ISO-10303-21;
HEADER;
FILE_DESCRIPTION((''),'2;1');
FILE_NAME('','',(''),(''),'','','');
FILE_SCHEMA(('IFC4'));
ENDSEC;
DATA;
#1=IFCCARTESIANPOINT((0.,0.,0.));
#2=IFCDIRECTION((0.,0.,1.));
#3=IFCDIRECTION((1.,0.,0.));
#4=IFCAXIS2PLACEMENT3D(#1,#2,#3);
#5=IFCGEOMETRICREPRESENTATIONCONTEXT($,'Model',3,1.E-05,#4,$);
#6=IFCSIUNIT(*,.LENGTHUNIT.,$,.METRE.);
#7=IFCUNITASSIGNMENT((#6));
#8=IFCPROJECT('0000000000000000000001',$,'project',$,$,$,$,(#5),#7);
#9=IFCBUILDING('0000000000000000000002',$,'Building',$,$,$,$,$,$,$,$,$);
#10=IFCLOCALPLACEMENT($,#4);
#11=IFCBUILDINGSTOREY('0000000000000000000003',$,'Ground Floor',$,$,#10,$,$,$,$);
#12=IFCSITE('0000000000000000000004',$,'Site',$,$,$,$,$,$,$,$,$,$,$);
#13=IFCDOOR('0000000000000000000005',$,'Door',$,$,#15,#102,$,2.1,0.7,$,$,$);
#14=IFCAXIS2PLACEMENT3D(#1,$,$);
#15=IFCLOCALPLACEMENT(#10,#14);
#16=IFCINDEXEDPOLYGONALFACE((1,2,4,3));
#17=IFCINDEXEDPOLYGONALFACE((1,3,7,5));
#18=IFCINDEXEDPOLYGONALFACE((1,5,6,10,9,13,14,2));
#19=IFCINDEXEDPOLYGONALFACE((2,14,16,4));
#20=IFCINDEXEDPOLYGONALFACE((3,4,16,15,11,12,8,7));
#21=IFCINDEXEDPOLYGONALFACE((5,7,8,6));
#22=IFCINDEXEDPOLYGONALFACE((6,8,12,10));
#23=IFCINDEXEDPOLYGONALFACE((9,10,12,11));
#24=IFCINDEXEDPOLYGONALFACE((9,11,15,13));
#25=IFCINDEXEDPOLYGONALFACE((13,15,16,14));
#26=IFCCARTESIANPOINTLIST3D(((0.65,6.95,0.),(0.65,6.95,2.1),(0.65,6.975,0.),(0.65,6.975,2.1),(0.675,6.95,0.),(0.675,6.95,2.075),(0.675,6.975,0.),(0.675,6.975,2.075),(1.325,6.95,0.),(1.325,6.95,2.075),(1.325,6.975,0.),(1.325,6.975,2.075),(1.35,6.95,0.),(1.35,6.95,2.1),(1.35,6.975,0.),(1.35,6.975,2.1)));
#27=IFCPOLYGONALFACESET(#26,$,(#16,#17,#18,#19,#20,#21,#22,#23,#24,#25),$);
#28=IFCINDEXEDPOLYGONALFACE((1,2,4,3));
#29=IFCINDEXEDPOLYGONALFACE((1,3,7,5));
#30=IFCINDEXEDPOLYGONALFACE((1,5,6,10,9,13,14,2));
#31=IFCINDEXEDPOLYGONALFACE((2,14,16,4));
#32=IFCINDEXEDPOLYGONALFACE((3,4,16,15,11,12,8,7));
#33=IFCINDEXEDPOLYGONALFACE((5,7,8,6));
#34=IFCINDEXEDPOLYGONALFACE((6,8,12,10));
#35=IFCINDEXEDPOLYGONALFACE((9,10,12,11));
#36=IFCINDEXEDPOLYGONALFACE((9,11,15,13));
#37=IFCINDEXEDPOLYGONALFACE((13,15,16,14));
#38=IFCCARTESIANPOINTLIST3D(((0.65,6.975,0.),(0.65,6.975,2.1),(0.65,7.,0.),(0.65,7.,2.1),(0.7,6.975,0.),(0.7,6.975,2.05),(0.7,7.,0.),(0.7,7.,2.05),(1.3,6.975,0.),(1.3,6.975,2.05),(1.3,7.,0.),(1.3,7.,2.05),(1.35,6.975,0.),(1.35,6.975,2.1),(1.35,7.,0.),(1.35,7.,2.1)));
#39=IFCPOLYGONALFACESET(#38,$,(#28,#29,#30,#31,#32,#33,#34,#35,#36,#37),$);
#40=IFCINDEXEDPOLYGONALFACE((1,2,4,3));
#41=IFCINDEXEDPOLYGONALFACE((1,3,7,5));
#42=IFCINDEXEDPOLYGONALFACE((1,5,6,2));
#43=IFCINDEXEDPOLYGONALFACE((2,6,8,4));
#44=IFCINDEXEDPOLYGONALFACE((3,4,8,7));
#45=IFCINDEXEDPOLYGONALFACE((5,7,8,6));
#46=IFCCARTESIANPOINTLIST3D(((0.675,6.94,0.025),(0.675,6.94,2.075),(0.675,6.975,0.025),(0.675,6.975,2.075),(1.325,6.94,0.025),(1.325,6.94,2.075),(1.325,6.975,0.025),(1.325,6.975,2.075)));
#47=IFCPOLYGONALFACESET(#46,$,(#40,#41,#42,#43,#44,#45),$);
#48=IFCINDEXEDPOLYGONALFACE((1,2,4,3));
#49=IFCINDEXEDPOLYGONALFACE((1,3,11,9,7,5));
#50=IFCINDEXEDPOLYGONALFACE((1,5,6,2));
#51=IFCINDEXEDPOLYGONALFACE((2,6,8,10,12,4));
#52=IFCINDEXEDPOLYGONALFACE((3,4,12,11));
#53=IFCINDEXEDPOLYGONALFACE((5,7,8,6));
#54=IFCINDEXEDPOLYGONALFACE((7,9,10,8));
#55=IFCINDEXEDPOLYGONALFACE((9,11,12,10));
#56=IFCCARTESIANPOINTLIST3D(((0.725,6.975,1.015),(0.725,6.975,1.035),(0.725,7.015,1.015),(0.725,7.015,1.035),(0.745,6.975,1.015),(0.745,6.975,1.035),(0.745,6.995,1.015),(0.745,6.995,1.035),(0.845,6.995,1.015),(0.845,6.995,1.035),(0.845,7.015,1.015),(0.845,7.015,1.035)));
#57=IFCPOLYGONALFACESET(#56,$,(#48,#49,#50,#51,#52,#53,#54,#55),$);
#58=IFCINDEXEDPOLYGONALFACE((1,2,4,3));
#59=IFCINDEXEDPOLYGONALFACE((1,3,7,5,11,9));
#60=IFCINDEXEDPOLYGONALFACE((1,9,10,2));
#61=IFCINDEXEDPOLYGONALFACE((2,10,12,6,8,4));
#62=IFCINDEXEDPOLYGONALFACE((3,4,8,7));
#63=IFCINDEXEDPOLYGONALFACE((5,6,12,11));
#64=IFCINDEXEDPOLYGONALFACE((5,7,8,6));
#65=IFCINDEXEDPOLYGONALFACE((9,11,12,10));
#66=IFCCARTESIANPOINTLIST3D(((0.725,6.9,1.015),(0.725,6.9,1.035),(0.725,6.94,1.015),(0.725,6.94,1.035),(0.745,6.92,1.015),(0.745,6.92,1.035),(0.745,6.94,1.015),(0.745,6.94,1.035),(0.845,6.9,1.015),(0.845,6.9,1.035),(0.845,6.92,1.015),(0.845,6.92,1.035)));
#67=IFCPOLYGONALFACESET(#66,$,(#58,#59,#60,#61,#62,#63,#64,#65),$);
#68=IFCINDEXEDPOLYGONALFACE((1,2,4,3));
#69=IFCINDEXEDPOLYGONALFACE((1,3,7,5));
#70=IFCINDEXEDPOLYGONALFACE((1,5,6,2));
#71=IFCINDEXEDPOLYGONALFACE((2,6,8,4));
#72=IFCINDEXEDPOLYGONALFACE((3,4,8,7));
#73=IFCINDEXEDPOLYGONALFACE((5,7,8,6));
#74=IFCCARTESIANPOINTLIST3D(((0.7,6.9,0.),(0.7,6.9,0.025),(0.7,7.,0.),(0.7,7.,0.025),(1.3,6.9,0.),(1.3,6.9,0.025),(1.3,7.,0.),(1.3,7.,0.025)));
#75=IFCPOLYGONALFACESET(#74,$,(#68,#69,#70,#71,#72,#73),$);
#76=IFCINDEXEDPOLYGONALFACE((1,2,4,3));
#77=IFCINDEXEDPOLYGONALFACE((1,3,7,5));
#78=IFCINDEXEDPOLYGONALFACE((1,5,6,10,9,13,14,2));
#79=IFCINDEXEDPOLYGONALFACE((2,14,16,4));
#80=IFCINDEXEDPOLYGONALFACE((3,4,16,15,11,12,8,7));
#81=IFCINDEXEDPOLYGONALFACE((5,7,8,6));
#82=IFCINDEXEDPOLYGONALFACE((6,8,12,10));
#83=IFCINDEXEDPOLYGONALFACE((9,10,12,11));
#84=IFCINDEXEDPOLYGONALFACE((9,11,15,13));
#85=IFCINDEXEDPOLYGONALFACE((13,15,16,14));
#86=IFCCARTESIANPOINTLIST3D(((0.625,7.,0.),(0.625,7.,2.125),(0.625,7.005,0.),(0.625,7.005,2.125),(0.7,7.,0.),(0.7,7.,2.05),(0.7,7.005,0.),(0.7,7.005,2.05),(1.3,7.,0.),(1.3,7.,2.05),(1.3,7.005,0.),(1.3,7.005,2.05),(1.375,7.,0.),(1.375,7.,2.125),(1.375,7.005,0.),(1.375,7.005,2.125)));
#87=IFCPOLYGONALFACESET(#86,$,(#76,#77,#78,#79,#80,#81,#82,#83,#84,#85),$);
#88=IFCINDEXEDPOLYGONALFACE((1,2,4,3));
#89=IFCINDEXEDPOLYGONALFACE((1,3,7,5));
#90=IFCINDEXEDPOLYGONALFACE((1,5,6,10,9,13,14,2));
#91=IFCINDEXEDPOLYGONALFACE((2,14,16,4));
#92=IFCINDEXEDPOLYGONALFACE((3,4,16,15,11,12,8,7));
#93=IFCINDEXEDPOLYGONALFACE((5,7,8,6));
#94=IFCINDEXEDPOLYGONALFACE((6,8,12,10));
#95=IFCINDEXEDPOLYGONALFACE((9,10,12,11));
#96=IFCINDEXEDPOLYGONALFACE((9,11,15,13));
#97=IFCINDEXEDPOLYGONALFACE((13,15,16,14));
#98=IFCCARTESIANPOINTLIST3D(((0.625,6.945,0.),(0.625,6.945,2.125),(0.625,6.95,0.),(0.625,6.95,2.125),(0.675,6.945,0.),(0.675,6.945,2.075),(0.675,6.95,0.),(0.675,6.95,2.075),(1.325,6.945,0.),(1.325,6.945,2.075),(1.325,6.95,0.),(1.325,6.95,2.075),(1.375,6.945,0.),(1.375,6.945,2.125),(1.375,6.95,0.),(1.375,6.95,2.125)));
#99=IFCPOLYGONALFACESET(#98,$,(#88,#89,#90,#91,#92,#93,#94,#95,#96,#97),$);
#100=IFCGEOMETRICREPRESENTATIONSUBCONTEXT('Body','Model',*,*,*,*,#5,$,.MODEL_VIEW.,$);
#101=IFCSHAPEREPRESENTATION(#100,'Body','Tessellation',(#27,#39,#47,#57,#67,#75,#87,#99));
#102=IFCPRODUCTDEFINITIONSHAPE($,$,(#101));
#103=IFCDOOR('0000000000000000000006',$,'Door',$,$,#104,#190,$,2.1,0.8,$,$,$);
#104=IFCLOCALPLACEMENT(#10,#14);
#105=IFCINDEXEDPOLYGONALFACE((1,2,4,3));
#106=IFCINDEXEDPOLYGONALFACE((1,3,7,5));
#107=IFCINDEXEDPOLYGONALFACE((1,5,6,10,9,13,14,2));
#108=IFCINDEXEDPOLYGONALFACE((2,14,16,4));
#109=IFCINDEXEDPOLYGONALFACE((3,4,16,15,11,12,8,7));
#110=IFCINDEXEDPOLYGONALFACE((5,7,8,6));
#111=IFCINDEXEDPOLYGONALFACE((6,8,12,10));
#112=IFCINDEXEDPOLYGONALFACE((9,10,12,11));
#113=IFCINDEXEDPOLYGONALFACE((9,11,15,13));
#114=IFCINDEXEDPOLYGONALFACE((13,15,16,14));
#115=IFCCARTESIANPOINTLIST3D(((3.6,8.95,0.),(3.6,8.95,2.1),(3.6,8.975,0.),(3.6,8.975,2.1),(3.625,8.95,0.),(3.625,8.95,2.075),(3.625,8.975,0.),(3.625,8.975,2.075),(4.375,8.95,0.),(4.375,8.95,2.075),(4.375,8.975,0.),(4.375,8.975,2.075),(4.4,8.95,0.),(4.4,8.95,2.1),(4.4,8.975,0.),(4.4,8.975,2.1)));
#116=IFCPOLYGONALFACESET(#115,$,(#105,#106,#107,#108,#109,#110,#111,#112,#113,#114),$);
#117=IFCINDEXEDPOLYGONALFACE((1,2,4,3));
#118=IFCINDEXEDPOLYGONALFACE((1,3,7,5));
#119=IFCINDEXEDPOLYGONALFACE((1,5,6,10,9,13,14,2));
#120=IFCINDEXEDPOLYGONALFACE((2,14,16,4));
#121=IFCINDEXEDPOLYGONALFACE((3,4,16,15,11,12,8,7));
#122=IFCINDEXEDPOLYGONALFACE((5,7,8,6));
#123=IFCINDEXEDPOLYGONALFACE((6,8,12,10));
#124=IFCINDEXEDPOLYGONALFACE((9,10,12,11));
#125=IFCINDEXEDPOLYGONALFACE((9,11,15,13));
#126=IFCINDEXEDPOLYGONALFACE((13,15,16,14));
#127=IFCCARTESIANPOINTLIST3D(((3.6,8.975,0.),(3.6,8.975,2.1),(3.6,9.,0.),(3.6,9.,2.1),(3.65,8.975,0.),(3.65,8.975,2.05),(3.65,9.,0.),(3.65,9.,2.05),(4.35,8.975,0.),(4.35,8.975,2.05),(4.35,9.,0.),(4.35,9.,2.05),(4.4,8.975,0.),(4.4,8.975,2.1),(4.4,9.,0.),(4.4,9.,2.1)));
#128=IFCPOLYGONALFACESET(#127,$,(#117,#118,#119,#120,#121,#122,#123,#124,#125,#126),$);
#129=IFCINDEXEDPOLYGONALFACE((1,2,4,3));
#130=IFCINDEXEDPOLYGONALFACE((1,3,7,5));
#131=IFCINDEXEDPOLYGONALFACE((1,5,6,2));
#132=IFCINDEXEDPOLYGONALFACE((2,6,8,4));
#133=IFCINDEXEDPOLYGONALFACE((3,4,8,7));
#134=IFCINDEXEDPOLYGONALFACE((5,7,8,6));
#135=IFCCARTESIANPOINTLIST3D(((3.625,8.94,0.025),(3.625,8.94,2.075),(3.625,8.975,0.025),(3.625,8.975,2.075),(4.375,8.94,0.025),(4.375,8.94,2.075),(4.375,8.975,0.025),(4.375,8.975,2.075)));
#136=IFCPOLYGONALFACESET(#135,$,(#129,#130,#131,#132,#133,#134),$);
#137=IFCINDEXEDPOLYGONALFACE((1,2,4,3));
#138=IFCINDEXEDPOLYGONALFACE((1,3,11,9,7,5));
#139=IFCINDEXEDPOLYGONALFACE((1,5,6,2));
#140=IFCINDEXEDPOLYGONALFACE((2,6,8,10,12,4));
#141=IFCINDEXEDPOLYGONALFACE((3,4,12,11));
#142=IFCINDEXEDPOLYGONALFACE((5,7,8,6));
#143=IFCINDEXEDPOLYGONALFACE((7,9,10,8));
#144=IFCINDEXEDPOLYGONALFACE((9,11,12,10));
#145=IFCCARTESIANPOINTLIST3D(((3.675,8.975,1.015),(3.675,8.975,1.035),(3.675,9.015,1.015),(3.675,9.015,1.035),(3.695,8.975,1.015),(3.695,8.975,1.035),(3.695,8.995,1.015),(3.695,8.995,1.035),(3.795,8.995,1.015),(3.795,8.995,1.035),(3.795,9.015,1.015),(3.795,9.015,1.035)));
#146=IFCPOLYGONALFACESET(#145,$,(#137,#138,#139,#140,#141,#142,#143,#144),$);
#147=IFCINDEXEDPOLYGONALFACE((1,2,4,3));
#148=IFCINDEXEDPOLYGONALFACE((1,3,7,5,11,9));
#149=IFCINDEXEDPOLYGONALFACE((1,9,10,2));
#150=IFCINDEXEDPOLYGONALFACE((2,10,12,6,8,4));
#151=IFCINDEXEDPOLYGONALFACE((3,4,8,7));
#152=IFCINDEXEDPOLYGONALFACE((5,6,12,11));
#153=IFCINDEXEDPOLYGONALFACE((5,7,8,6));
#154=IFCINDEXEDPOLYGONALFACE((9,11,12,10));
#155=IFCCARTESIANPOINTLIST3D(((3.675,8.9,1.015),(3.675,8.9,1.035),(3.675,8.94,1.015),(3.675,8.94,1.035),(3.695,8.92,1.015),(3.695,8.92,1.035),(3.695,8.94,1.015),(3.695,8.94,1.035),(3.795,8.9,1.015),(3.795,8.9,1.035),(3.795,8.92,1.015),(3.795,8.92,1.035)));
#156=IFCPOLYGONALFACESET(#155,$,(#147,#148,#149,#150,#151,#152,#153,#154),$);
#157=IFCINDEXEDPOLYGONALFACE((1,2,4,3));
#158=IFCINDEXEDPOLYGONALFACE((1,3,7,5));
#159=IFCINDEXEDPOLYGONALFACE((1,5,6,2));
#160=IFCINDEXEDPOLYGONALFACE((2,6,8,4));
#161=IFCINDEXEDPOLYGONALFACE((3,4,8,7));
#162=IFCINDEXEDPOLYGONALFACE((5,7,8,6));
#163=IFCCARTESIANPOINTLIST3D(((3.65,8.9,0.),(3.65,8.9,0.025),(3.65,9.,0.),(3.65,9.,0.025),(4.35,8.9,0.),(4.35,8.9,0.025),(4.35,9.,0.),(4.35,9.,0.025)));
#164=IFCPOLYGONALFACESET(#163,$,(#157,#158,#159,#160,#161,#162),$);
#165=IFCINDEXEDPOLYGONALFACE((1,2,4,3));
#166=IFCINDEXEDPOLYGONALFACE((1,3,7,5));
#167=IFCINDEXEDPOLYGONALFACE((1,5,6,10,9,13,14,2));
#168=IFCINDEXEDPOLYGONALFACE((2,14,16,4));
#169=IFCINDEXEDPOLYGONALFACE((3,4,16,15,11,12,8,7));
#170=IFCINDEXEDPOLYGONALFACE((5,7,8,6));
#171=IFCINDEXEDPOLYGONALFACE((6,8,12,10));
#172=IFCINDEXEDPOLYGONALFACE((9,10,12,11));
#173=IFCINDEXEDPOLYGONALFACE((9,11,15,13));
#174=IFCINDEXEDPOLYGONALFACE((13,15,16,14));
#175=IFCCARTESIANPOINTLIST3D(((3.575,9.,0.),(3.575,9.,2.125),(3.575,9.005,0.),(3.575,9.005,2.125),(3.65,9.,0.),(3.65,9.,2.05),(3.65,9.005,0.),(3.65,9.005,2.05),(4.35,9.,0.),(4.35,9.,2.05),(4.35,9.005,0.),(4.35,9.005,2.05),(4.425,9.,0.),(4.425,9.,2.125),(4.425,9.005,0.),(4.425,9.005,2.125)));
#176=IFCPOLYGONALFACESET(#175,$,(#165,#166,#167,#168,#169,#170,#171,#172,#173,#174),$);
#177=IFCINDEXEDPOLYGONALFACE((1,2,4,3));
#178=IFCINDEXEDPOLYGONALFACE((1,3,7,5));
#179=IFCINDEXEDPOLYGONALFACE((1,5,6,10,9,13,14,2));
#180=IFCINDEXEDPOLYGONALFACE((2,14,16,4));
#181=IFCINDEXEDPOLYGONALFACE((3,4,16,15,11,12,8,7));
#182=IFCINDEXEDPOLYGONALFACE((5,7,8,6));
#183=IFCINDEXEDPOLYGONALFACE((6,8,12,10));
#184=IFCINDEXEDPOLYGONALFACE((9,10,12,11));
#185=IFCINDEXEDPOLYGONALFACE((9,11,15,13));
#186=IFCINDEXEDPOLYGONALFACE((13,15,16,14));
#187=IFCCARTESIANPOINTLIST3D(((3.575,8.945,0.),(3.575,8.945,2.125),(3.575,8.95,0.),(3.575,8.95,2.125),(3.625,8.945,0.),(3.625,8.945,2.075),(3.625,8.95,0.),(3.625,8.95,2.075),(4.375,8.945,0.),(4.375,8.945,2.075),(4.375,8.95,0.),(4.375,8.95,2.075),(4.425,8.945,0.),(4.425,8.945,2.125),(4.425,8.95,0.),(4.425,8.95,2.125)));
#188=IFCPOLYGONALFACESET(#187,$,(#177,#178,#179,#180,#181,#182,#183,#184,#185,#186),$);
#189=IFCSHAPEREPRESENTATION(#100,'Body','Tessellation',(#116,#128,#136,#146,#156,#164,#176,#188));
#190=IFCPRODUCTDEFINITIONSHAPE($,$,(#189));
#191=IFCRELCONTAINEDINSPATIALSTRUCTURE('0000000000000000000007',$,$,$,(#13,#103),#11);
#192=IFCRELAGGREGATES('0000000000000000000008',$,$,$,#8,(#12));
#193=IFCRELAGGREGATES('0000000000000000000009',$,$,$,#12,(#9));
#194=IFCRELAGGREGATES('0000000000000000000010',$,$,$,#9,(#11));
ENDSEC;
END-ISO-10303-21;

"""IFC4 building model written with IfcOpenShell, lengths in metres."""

from ifc_helpers import new_model, si_unit, frame, origin_with_axes, place, context, subcontext, project, spatial, line, indexed_curve, outline, extrude, element, save


model = new_model("IFC4")

# Units and contexts
model_context = context("Model", 3, precision=1e-05, world=origin_with_axes())
body_context = subcontext(model_context, "Body", "Model", "MODEL_VIEW")
ifc_project = project(units=[si_unit("LENGTHUNIT", "METRE")], contexts=[model_context])

# Site, building, storey
site = spatial("IfcSite", under=ifc_project, Name="Site")
building = spatial("IfcBuilding", under=site, Name="Building")
storey_placement = place(None, origin_with_axes())
storey = spatial("IfcBuildingStorey", under=building, at=storey_placement, Name="Ground Floor")

# Doors
door_1_placement = place(storey_placement, frame((1.35, 7.0, 0.0), z_axis=(0.0, 0.0, 1.0), x_axis=(-1.0, 0.0, 0.0)))
element("IfcDoor", 1, at=door_1_placement, inside=storey, Name="Door", OverallHeight=2.1, OverallWidth=0.7, context=body_context, shape_type="SweptSolid", body=[
    extrude(outline(indexed_curve([(0.0, 0.0), (0.0, 2.1), (0.7, 2.1), (0.7, 0.0), (0.675, 0.0), (0.675, 2.075), (0.025, 2.075), (0.025, 0.0)], segments=[line(1, 2, 3, 4, 5, 6, 7, 8, 1)])), frame((0.0, 0.025, 0.0), z_axis=(0.0, -1.0, 0.0), x_axis=(1.0, 0.0, 0.0)), (0.0, 0.0, -1.0), 0.025),
    extrude(outline(indexed_curve([(0.0, 0.0), (0.0, 2.1), (0.7, 2.1), (0.7, 0.0), (0.65, 0.0), (0.65, 2.05), (0.05, 2.05), (0.05, 0.0)], segments=[line(1, 2, 3, 4, 5, 6, 7, 8, 1)])), frame((0.0, 0.0, 0.0), z_axis=(0.0, -1.0, 0.0), x_axis=(1.0, 0.0, 0.0)), (0.0, 0.0, -1.0), 0.025),
    extrude(outline(indexed_curve([(0.0, 0.0), (0.65, 0.0), (0.65, 0.035), (0.0, 0.035)], segments=[line(1, 2, 3, 4, 1)])), frame((0.025, 0.025, 0.025), z_axis=(0.0, 0.0, 1.0), x_axis=(1.0, 0.0, 0.0)), (0.0, 0.0, 1.0), 2.05),
    extrude(outline(indexed_curve([(0.0, 0.0), (0.0, -0.04), (-0.12, -0.04), (-0.12, -0.02), (-0.02, -0.02), (-0.02, 0.0)], segments=[line(1, 2, 3, 4, 5, 6, 1)])), frame((0.625, 0.025, 1.015), z_axis=(0.0, 0.0, 1.0), x_axis=(1.0, 0.0, 0.0)), (0.0, 0.0, 1.0), 0.02),
    extrude(outline(indexed_curve([(0.0, 0.0), (0.0, 0.04), (-0.12, 0.04), (-0.12, 0.02), (-0.02, 0.02), (-0.02, 0.0)], segments=[line(1, 2, 3, 4, 5, 6, 1)])), frame((0.625, 0.06, 1.015), z_axis=(0.0, 0.0, 1.0), x_axis=(1.0, 0.0, 0.0)), (0.0, 0.0, 1.0), 0.02),
    extrude(outline(indexed_curve([(0.0, 0.0), (0.6, 0.0), (0.6, 0.1), (0.0, 0.1)], segments=[line(1, 2, 3, 4, 1)])), frame((0.05, 0.0, 0.0), z_axis=(0.0, 0.0, 1.0), x_axis=(1.0, 0.0, 0.0)), (0.0, 0.0, 1.0), 0.025),
    extrude(outline(indexed_curve([(0.0, 0.0), (0.0, 2.125), (0.75, 2.125), (0.75, 0.0), (0.675, 0.0), (0.675, 2.05), (0.075, 2.05), (0.075, 0.0)], segments=[line(1, 2, 3, 4, 5, 6, 7, 8, 1)])), frame((-0.025, -0.005, 0.0), z_axis=(0.0, -1.0, 0.0), x_axis=(1.0, 0.0, 0.0)), (0.0, 0.0, -1.0), 0.005),
    extrude(outline(indexed_curve([(0.0, 0.0), (0.0, 2.125), (0.75, 2.125), (0.75, 0.0), (0.7, 0.0), (0.7, 2.075), (0.05, 2.075), (0.05, 0.0)], segments=[line(1, 2, 3, 4, 5, 6, 7, 8, 1)])), frame((-0.025, 0.05, 0.0), z_axis=(0.0, -1.0, 0.0), x_axis=(1.0, 0.0, 0.0)), (0.0, 0.0, -1.0), 0.005),
])
door_2_placement = place(storey_placement, frame((4.4, 9.0, 0.0), z_axis=(0.0, 0.0, 1.0), x_axis=(-1.0, 0.0, 0.0)))
element("IfcDoor", 2, at=door_2_placement, inside=storey, Name="Door", OverallHeight=2.1, OverallWidth=0.8, context=body_context, shape_type="SweptSolid", body=[
    extrude(outline(indexed_curve([(0.0, 0.0), (0.0, 2.1), (0.8, 2.1), (0.8, 0.0), (0.775, 0.0), (0.775, 2.075), (0.025, 2.075), (0.025, 0.0)], segments=[line(1, 2, 3, 4, 5, 6, 7, 8, 1)])), frame((0.0, 0.025, 0.0), z_axis=(0.0, -1.0, 0.0), x_axis=(1.0, 0.0, 0.0)), (0.0, 0.0, -1.0), 0.025),
    extrude(outline(indexed_curve([(0.0, 0.0), (0.0, 2.1), (0.8, 2.1), (0.8, 0.0), (0.75, 0.0), (0.75, 2.05), (0.05, 2.05), (0.05, 0.0)], segments=[line(1, 2, 3, 4, 5, 6, 7, 8, 1)])), frame((0.0, 0.0, 0.0), z_axis=(0.0, -1.0, 0.0), x_axis=(1.0, 0.0, 0.0)), (0.0, 0.0, -1.0), 0.025),
    extrude(outline(indexed_curve([(0.0, 0.0), (0.75, 0.0), (0.75, 0.035), (0.0, 0.035)], segments=[line(1, 2, 3, 4, 1)])), frame((0.025, 0.025, 0.025), z_axis=(0.0, 0.0, 1.0), x_axis=(1.0, 0.0, 0.0)), (0.0, 0.0, 1.0), 2.05),
    extrude(outline(indexed_curve([(0.0, 0.0), (0.0, -0.04), (-0.12, -0.04), (-0.12, -0.02), (-0.02, -0.02), (-0.02, 0.0)], segments=[line(1, 2, 3, 4, 5, 6, 1)])), frame((0.725, 0.025, 1.015), z_axis=(0.0, 0.0, 1.0), x_axis=(1.0, 0.0, 0.0)), (0.0, 0.0, 1.0), 0.02),
    extrude(outline(indexed_curve([(0.0, 0.0), (0.0, 0.04), (-0.12, 0.04), (-0.12, 0.02), (-0.02, 0.02), (-0.02, 0.0)], segments=[line(1, 2, 3, 4, 5, 6, 1)])), frame((0.725, 0.06, 1.015), z_axis=(0.0, 0.0, 1.0), x_axis=(1.0, 0.0, 0.0)), (0.0, 0.0, 1.0), 0.02),
    extrude(outline(indexed_curve([(0.0, 0.0), (0.7, 0.0), (0.7, 0.1), (0.0, 0.1)], segments=[line(1, 2, 3, 4, 1)])), frame((0.05, 0.0, 0.0), z_axis=(0.0, 0.0, 1.0), x_axis=(1.0, 0.0, 0.0)), (0.0, 0.0, 1.0), 0.025),
    extrude(outline(indexed_curve([(0.0, 0.0), (0.0, 2.125), (0.85, 2.125), (0.85, 0.0), (0.775, 0.0), (0.775, 2.05), (0.075, 2.05), (0.075, 0.0)], segments=[line(1, 2, 3, 4, 5, 6, 7, 8, 1)])), frame((-0.025, -0.005, 0.0), z_axis=(0.0, -1.0, 0.0), x_axis=(1.0, 0.0, 0.0)), (0.0, 0.0, -1.0), 0.005),
    extrude(outline(indexed_curve([(0.0, 0.0), (0.0, 2.125), (0.85, 2.125), (0.85, 0.0), (0.8, 0.0), (0.8, 2.075), (0.05, 2.075), (0.05, 0.0)], segments=[line(1, 2, 3, 4, 5, 6, 7, 8, 1)])), frame((-0.025, 0.05, 0.0), z_axis=(0.0, -1.0, 0.0), x_axis=(1.0, 0.0, 0.0)), (0.0, 0.0, -1.0), 0.005),
])

save(model, "model.ifc")
